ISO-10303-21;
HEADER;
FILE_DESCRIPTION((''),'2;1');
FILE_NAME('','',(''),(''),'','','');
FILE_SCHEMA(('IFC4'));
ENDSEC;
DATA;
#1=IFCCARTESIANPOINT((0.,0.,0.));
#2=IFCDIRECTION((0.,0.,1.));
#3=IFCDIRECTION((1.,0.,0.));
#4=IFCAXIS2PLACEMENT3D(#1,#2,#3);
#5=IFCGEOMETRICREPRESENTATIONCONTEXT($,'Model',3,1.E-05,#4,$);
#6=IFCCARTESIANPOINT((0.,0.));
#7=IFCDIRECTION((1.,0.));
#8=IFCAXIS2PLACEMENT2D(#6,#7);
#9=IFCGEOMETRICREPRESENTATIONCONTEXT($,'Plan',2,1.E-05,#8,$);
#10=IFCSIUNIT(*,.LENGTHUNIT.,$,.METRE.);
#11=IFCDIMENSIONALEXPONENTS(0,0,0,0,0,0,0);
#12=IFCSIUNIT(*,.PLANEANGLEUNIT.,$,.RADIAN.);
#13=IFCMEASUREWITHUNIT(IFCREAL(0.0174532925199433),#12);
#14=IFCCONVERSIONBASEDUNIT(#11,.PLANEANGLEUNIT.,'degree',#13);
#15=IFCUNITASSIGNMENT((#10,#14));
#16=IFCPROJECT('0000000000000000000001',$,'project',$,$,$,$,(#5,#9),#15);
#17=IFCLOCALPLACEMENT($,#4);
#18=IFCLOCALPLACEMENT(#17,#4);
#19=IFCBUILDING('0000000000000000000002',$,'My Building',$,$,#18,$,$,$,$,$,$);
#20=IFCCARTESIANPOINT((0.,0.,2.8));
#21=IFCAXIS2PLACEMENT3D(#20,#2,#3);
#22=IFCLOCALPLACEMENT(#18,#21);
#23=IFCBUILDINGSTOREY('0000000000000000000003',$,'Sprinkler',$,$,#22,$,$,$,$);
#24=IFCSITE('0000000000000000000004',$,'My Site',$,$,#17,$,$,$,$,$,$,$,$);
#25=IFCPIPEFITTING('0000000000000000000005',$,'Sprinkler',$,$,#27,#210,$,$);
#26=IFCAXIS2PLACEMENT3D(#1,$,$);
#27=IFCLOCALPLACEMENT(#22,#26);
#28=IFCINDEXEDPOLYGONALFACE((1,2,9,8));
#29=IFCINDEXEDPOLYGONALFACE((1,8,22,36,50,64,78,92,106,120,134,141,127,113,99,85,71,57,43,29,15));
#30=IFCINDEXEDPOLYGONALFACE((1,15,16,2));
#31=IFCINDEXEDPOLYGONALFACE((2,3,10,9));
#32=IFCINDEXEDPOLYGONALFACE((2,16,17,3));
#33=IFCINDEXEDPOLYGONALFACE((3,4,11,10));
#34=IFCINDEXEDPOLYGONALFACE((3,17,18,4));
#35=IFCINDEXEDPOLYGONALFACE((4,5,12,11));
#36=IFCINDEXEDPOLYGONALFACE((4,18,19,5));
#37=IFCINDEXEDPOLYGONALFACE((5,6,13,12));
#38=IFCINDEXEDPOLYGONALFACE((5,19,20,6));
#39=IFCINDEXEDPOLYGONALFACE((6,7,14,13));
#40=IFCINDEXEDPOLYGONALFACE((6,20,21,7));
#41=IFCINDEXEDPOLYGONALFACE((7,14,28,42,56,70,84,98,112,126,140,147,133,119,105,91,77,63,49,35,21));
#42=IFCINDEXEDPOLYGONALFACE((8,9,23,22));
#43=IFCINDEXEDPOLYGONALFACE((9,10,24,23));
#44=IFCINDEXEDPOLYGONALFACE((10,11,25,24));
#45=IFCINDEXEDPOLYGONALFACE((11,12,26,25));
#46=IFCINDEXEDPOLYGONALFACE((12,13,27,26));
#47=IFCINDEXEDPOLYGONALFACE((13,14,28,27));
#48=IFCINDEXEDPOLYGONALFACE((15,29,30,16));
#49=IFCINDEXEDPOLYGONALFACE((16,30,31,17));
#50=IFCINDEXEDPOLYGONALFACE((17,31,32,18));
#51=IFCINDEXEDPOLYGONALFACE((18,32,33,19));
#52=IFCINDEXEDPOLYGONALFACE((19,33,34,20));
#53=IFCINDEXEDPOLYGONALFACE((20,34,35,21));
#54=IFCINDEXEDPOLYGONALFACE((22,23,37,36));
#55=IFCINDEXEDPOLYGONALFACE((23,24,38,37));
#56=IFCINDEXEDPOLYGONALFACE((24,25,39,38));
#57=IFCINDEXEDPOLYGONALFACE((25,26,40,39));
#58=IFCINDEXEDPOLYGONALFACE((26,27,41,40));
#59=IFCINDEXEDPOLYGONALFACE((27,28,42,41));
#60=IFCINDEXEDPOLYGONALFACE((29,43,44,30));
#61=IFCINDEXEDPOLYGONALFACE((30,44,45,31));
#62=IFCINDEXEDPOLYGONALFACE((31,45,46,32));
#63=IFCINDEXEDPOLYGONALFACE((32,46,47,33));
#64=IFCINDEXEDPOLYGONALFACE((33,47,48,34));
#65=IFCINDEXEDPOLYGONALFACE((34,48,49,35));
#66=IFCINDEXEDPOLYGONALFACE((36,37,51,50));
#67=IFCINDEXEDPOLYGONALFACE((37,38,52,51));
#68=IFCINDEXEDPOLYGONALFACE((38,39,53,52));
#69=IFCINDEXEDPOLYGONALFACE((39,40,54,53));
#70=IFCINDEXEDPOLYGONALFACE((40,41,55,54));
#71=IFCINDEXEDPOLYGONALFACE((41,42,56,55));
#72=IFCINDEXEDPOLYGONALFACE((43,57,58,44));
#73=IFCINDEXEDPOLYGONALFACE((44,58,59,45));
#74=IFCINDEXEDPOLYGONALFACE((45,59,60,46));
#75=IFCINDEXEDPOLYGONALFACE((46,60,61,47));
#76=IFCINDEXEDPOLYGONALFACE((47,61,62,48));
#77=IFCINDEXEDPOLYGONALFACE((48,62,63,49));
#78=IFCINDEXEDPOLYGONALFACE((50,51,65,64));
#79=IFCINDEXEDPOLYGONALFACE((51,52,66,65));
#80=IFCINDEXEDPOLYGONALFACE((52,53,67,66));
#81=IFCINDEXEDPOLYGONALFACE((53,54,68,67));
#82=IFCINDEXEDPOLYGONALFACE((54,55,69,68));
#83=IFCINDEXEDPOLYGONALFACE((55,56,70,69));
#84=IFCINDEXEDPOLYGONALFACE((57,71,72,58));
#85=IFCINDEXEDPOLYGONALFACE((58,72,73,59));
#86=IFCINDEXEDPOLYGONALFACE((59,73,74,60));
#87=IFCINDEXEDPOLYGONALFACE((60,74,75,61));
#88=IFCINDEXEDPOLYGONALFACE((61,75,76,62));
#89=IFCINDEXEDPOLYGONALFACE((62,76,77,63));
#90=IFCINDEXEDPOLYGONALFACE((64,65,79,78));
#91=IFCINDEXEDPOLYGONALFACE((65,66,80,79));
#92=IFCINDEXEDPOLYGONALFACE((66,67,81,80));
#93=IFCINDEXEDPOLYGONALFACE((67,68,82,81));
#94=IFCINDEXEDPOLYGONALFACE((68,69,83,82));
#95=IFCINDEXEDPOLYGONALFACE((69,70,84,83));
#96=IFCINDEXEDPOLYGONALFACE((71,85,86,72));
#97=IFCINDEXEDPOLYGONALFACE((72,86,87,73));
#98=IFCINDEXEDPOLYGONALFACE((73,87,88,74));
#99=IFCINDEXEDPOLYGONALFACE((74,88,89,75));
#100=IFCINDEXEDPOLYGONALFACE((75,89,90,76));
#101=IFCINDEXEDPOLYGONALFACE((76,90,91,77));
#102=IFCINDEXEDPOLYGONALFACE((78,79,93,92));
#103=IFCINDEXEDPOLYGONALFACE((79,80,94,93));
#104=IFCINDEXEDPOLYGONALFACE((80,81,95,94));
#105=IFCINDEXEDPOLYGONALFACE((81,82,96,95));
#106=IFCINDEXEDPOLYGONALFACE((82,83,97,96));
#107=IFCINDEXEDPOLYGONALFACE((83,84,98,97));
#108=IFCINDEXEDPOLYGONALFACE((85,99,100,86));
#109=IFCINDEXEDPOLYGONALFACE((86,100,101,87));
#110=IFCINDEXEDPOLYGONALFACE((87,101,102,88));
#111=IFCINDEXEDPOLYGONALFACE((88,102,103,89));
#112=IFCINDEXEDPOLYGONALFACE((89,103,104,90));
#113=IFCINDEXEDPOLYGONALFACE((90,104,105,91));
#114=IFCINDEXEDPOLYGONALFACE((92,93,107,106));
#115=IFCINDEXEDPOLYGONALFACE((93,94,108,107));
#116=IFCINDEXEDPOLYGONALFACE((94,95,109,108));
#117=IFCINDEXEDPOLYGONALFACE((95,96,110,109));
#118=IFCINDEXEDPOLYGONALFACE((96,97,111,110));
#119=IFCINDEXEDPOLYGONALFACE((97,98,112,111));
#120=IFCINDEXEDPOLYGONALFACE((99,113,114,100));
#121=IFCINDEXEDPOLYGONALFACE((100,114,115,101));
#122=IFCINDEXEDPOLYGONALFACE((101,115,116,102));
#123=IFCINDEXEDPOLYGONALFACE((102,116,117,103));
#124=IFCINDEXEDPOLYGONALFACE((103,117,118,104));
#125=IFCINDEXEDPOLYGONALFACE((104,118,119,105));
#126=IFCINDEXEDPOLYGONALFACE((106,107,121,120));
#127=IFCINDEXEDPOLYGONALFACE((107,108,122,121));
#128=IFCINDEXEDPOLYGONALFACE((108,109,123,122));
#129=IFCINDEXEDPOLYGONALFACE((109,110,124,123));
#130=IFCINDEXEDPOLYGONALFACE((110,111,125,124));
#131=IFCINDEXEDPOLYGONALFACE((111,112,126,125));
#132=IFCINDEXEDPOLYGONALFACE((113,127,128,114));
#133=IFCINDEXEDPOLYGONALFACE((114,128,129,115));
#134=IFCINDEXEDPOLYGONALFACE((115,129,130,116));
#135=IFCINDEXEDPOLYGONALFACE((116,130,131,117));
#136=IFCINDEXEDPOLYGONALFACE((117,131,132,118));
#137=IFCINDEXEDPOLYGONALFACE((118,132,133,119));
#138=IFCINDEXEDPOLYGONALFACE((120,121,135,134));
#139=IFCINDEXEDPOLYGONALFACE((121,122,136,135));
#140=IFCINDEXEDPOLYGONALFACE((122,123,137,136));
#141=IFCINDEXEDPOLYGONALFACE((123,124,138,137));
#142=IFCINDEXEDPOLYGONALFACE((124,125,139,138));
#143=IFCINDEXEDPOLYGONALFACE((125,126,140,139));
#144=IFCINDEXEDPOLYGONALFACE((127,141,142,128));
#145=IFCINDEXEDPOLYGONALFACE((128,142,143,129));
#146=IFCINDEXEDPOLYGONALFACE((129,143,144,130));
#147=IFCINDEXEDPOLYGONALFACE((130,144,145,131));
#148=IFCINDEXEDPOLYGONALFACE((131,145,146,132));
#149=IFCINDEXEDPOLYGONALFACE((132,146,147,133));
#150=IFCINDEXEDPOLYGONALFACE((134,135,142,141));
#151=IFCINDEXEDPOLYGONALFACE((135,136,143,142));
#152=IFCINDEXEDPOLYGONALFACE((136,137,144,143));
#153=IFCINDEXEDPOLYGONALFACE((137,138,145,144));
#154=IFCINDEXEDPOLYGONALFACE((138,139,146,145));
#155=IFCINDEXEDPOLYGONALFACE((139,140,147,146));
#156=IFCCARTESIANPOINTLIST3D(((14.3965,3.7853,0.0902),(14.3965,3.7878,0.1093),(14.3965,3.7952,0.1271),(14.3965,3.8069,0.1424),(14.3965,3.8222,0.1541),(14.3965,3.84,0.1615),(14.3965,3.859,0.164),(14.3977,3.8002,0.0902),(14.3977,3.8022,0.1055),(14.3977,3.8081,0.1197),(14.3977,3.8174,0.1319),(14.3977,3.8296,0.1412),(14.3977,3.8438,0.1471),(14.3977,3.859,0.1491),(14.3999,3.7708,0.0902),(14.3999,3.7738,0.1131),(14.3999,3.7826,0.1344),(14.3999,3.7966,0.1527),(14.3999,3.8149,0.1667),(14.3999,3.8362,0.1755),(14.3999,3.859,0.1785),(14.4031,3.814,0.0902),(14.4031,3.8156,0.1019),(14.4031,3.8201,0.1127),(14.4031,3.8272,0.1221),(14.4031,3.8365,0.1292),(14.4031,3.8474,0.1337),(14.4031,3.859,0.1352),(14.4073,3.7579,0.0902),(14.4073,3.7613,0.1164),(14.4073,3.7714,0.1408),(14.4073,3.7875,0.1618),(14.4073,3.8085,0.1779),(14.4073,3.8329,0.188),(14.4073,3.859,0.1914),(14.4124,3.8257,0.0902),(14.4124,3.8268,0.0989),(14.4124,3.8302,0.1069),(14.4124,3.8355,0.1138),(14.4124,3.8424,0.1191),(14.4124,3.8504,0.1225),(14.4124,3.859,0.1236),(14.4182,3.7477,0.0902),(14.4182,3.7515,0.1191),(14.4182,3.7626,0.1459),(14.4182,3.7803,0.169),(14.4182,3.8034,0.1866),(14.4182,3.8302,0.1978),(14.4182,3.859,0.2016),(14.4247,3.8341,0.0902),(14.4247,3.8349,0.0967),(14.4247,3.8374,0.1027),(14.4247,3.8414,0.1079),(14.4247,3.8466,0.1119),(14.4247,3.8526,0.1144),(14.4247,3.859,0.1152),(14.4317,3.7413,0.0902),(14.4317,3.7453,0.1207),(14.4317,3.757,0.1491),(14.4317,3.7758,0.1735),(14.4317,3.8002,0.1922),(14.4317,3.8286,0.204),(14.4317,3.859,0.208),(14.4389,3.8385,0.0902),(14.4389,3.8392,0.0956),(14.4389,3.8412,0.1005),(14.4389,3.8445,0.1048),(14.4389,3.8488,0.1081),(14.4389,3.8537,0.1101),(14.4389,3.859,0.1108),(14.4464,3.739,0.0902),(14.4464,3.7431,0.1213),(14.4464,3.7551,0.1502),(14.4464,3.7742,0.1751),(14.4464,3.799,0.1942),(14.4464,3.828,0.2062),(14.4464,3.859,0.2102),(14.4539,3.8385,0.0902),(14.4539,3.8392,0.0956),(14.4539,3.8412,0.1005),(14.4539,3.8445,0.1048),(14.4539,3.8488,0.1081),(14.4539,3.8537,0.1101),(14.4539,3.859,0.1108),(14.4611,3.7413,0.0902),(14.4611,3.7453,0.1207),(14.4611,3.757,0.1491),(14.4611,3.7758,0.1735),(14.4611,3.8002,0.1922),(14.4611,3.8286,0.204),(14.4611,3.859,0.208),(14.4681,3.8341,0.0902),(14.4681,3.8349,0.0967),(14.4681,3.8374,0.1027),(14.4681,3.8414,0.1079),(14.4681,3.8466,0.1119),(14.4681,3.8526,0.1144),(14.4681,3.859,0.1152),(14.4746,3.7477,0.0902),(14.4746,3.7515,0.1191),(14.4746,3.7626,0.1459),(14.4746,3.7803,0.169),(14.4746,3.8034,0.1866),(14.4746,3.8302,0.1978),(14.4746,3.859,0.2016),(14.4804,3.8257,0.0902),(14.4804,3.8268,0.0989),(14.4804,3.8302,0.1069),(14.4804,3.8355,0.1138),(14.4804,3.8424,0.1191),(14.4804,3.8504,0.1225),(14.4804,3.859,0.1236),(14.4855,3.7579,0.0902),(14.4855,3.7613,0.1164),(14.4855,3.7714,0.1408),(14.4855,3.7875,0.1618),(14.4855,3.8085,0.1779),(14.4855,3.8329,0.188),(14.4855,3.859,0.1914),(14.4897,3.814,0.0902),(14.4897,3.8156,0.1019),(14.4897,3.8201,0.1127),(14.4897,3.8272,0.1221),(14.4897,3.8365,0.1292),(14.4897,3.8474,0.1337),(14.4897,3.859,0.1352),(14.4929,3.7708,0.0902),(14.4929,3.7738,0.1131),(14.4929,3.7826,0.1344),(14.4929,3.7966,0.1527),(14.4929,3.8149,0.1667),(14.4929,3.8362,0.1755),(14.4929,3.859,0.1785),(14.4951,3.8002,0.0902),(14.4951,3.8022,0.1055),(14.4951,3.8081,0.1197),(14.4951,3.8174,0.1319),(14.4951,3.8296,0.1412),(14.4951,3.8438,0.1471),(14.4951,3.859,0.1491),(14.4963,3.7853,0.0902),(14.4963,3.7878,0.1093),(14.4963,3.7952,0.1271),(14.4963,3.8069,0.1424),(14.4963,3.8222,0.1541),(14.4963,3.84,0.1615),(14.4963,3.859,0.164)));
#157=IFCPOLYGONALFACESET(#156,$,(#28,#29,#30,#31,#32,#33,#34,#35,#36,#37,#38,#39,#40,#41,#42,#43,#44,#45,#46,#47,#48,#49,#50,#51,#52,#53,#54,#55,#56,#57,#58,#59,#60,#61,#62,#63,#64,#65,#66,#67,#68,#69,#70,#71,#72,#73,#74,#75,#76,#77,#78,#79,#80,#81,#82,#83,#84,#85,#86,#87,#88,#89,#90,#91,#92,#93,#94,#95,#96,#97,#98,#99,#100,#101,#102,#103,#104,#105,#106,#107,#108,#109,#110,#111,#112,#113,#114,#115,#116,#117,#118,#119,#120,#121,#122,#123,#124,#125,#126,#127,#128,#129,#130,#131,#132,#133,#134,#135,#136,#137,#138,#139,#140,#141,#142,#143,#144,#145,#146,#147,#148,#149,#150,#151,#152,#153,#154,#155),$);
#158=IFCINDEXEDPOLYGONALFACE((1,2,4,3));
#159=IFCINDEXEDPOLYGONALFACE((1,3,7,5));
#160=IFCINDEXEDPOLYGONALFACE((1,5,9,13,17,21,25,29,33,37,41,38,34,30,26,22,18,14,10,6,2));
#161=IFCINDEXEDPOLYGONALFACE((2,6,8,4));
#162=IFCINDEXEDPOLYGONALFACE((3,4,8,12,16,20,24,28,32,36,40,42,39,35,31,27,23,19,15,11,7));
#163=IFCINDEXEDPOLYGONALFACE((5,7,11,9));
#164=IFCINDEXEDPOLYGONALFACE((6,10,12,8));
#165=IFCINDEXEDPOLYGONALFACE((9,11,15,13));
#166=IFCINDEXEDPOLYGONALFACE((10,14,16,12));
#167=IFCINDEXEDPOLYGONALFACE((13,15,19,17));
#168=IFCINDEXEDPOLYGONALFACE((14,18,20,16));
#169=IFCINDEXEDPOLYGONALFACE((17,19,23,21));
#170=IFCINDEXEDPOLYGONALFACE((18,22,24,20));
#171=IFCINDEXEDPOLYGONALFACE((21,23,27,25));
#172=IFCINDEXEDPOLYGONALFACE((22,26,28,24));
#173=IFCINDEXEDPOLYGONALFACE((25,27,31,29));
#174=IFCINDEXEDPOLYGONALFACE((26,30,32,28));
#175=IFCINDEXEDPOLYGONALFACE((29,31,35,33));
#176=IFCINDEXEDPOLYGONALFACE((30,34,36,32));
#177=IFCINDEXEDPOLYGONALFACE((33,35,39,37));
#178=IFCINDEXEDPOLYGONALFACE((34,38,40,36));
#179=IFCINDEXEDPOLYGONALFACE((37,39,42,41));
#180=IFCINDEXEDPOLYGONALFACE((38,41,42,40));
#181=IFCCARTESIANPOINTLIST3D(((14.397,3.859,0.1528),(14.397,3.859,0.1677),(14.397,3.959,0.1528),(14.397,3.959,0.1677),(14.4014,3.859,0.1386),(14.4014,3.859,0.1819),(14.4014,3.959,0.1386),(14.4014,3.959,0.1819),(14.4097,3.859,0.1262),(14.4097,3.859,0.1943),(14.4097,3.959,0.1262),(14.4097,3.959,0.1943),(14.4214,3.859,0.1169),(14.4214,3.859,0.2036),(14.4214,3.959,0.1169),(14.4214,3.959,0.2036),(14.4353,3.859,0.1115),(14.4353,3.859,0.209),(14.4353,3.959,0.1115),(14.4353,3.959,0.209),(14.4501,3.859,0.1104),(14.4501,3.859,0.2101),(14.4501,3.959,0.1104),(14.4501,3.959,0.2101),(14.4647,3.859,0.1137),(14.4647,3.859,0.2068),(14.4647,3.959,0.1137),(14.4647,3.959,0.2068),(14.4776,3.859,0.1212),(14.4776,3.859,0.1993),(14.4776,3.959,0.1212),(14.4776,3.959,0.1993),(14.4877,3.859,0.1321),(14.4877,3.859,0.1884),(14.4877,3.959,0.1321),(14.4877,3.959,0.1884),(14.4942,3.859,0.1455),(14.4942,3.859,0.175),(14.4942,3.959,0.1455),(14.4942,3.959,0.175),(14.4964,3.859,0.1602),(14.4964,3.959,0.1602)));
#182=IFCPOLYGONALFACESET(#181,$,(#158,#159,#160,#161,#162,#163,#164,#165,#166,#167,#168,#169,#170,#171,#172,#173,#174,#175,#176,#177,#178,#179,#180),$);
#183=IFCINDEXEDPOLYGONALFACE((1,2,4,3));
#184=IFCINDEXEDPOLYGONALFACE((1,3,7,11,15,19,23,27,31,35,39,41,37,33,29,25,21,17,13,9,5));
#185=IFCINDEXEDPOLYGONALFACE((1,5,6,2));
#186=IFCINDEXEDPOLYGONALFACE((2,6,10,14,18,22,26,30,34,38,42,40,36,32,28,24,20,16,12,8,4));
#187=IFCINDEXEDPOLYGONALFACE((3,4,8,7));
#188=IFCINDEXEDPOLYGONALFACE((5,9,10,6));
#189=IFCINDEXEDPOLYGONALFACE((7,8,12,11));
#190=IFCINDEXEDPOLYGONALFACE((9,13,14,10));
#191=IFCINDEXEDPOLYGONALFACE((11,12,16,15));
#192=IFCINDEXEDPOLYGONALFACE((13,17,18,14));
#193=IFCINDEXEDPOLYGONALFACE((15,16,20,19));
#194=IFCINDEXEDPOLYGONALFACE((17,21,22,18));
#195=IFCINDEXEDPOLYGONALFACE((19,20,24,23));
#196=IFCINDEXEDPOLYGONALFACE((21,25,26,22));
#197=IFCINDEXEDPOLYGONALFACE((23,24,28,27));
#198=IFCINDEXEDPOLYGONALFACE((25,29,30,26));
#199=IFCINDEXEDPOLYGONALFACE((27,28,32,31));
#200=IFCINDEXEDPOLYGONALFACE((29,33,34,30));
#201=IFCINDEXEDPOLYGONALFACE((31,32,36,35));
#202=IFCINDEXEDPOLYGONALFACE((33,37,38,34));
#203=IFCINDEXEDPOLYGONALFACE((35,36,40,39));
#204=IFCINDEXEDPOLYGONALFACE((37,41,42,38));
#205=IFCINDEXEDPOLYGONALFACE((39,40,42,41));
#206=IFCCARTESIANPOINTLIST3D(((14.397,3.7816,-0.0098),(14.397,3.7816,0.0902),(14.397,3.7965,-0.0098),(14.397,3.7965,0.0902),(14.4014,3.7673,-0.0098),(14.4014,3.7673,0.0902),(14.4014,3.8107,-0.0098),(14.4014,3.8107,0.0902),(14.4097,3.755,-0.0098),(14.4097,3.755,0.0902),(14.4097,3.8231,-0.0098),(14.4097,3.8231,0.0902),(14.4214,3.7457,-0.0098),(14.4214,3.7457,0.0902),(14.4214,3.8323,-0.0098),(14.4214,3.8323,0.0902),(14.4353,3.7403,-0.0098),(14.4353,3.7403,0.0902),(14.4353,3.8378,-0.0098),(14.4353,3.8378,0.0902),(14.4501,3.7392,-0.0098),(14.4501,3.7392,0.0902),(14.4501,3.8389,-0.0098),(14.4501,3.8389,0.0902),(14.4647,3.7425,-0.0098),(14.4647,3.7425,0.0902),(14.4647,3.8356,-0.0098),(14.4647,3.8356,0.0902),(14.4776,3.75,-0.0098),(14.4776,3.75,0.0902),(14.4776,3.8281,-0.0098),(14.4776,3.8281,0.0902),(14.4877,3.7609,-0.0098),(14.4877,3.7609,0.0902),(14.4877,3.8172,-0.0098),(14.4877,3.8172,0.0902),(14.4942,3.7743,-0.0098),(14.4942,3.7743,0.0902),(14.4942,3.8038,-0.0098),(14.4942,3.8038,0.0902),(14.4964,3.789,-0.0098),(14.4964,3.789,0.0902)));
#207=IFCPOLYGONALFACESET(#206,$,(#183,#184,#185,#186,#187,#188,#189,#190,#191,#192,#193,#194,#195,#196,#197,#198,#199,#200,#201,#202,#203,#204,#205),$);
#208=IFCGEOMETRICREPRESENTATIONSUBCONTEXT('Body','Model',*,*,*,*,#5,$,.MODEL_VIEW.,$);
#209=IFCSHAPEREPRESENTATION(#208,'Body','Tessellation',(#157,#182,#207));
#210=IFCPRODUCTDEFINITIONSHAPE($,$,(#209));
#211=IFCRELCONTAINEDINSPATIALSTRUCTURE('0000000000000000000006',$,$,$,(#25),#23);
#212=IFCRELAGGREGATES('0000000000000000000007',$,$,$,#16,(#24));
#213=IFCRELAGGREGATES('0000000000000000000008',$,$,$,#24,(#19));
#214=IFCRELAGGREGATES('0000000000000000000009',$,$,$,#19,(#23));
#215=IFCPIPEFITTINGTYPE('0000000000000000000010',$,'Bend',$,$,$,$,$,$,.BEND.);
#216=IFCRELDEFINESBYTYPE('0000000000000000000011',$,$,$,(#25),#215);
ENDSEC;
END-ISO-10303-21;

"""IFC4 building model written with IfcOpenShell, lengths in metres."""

from ifc_helpers import new_model, entity, si_unit, converted_unit, frame, origin_with_axes, origin_2d_with_axis, place, context, subcontext, project, spatial, circle, extrude, source, transform, mapped, type_object, type_shapes, element, save


model = new_model("IFC4")

# Units and contexts
model_context = context("Model", 3, precision=1e-05, world=origin_with_axes())
plan_context = context("Plan", 2, precision=1e-05, world=origin_2d_with_axis())
body_context = subcontext(model_context, "Body", "Model", "MODEL_VIEW")
ifc_project = project(units=[si_unit("LENGTHUNIT", "METRE"), converted_unit("PLANEANGLEUNIT", "degree", entity("IfcReal", 0.0174532925199433), si_unit("PLANEANGLEUNIT", "RADIAN"), dimensions=[0, 0, 0, 0, 0, 0, 0])], contexts=[model_context, plan_context])

# Site, building, storey
site_placement = place(None, origin_with_axes())
site = spatial("IfcSite", under=ifc_project, at=site_placement, Name="My Site")
building_placement = place(site_placement, origin_with_axes())
building = spatial("IfcBuilding", under=site, at=building_placement, Name="My Building")
storey_placement = place(building_placement, frame((0.0, 0.0, 2.8), z_axis=(0.0, 0.0, 1.0), x_axis=(1.0, 0.0, 0.0)))
storey = spatial("IfcBuildingStorey", under=building, at=storey_placement, Name="Sprinkler")

# Pipe fitting
pipe_fitting_type_1 = type_object("IfcPipeFittingType", Name="Bend", PredefinedType="BEND")
shared_shape_1 = source(origin_with_axes(), body_context, "Body", "SolidModel", [
    entity("IfcSweptDiskSolid", entity("IfcIndexedPolyCurve", entity("IfcCartesianPointList3D", [[0.0, 0.0, 0.1], [0.0, -0.0205, 0.1495], [0.0, -0.07, 0.17]]), [entity("IfcArcIndex", [1, 2, 3])]), 0.05),
    extrude(circle(Radius=0.05), origin_with_axes(), (0.0, 0.0, 1.0), 0.1),
    extrude(circle(Radius=0.05), frame((0.0, -0.07, 0.17), z_axis=(0.0, -1.0, 0.0), x_axis=(1.0, 0.0, 0.0)), (0.0, 0.0, 1.0), 0.1),
])
type_shapes(pipe_fitting_type_1, [shared_shape_1])
for number, where, z_axis, x_axis, name in (
    (1, (14.4464, 3.959, 0.1602), (0.0, -1.0, 0.0), (1.0, 0.0, 0.0), "Sprinkler"),
):
    element("IfcPipeFitting", number, at=place(storey_placement, frame(where, z_axis=z_axis, x_axis=x_axis)), inside=storey, type_object=pipe_fitting_type_1, Name=name, context=body_context, shape_type="MappedRepresentation", body=[
        mapped(shared_shape_1, transform((0.0, 0.0, 0.0), x_axis=(1.0, 0.0, 0.0), y_axis=(0.0, 1.0, 0.0), z_axis=(0.0, 0.0, 1.0), scale=1.0)),
    ])

save(model, "model.ifc")
